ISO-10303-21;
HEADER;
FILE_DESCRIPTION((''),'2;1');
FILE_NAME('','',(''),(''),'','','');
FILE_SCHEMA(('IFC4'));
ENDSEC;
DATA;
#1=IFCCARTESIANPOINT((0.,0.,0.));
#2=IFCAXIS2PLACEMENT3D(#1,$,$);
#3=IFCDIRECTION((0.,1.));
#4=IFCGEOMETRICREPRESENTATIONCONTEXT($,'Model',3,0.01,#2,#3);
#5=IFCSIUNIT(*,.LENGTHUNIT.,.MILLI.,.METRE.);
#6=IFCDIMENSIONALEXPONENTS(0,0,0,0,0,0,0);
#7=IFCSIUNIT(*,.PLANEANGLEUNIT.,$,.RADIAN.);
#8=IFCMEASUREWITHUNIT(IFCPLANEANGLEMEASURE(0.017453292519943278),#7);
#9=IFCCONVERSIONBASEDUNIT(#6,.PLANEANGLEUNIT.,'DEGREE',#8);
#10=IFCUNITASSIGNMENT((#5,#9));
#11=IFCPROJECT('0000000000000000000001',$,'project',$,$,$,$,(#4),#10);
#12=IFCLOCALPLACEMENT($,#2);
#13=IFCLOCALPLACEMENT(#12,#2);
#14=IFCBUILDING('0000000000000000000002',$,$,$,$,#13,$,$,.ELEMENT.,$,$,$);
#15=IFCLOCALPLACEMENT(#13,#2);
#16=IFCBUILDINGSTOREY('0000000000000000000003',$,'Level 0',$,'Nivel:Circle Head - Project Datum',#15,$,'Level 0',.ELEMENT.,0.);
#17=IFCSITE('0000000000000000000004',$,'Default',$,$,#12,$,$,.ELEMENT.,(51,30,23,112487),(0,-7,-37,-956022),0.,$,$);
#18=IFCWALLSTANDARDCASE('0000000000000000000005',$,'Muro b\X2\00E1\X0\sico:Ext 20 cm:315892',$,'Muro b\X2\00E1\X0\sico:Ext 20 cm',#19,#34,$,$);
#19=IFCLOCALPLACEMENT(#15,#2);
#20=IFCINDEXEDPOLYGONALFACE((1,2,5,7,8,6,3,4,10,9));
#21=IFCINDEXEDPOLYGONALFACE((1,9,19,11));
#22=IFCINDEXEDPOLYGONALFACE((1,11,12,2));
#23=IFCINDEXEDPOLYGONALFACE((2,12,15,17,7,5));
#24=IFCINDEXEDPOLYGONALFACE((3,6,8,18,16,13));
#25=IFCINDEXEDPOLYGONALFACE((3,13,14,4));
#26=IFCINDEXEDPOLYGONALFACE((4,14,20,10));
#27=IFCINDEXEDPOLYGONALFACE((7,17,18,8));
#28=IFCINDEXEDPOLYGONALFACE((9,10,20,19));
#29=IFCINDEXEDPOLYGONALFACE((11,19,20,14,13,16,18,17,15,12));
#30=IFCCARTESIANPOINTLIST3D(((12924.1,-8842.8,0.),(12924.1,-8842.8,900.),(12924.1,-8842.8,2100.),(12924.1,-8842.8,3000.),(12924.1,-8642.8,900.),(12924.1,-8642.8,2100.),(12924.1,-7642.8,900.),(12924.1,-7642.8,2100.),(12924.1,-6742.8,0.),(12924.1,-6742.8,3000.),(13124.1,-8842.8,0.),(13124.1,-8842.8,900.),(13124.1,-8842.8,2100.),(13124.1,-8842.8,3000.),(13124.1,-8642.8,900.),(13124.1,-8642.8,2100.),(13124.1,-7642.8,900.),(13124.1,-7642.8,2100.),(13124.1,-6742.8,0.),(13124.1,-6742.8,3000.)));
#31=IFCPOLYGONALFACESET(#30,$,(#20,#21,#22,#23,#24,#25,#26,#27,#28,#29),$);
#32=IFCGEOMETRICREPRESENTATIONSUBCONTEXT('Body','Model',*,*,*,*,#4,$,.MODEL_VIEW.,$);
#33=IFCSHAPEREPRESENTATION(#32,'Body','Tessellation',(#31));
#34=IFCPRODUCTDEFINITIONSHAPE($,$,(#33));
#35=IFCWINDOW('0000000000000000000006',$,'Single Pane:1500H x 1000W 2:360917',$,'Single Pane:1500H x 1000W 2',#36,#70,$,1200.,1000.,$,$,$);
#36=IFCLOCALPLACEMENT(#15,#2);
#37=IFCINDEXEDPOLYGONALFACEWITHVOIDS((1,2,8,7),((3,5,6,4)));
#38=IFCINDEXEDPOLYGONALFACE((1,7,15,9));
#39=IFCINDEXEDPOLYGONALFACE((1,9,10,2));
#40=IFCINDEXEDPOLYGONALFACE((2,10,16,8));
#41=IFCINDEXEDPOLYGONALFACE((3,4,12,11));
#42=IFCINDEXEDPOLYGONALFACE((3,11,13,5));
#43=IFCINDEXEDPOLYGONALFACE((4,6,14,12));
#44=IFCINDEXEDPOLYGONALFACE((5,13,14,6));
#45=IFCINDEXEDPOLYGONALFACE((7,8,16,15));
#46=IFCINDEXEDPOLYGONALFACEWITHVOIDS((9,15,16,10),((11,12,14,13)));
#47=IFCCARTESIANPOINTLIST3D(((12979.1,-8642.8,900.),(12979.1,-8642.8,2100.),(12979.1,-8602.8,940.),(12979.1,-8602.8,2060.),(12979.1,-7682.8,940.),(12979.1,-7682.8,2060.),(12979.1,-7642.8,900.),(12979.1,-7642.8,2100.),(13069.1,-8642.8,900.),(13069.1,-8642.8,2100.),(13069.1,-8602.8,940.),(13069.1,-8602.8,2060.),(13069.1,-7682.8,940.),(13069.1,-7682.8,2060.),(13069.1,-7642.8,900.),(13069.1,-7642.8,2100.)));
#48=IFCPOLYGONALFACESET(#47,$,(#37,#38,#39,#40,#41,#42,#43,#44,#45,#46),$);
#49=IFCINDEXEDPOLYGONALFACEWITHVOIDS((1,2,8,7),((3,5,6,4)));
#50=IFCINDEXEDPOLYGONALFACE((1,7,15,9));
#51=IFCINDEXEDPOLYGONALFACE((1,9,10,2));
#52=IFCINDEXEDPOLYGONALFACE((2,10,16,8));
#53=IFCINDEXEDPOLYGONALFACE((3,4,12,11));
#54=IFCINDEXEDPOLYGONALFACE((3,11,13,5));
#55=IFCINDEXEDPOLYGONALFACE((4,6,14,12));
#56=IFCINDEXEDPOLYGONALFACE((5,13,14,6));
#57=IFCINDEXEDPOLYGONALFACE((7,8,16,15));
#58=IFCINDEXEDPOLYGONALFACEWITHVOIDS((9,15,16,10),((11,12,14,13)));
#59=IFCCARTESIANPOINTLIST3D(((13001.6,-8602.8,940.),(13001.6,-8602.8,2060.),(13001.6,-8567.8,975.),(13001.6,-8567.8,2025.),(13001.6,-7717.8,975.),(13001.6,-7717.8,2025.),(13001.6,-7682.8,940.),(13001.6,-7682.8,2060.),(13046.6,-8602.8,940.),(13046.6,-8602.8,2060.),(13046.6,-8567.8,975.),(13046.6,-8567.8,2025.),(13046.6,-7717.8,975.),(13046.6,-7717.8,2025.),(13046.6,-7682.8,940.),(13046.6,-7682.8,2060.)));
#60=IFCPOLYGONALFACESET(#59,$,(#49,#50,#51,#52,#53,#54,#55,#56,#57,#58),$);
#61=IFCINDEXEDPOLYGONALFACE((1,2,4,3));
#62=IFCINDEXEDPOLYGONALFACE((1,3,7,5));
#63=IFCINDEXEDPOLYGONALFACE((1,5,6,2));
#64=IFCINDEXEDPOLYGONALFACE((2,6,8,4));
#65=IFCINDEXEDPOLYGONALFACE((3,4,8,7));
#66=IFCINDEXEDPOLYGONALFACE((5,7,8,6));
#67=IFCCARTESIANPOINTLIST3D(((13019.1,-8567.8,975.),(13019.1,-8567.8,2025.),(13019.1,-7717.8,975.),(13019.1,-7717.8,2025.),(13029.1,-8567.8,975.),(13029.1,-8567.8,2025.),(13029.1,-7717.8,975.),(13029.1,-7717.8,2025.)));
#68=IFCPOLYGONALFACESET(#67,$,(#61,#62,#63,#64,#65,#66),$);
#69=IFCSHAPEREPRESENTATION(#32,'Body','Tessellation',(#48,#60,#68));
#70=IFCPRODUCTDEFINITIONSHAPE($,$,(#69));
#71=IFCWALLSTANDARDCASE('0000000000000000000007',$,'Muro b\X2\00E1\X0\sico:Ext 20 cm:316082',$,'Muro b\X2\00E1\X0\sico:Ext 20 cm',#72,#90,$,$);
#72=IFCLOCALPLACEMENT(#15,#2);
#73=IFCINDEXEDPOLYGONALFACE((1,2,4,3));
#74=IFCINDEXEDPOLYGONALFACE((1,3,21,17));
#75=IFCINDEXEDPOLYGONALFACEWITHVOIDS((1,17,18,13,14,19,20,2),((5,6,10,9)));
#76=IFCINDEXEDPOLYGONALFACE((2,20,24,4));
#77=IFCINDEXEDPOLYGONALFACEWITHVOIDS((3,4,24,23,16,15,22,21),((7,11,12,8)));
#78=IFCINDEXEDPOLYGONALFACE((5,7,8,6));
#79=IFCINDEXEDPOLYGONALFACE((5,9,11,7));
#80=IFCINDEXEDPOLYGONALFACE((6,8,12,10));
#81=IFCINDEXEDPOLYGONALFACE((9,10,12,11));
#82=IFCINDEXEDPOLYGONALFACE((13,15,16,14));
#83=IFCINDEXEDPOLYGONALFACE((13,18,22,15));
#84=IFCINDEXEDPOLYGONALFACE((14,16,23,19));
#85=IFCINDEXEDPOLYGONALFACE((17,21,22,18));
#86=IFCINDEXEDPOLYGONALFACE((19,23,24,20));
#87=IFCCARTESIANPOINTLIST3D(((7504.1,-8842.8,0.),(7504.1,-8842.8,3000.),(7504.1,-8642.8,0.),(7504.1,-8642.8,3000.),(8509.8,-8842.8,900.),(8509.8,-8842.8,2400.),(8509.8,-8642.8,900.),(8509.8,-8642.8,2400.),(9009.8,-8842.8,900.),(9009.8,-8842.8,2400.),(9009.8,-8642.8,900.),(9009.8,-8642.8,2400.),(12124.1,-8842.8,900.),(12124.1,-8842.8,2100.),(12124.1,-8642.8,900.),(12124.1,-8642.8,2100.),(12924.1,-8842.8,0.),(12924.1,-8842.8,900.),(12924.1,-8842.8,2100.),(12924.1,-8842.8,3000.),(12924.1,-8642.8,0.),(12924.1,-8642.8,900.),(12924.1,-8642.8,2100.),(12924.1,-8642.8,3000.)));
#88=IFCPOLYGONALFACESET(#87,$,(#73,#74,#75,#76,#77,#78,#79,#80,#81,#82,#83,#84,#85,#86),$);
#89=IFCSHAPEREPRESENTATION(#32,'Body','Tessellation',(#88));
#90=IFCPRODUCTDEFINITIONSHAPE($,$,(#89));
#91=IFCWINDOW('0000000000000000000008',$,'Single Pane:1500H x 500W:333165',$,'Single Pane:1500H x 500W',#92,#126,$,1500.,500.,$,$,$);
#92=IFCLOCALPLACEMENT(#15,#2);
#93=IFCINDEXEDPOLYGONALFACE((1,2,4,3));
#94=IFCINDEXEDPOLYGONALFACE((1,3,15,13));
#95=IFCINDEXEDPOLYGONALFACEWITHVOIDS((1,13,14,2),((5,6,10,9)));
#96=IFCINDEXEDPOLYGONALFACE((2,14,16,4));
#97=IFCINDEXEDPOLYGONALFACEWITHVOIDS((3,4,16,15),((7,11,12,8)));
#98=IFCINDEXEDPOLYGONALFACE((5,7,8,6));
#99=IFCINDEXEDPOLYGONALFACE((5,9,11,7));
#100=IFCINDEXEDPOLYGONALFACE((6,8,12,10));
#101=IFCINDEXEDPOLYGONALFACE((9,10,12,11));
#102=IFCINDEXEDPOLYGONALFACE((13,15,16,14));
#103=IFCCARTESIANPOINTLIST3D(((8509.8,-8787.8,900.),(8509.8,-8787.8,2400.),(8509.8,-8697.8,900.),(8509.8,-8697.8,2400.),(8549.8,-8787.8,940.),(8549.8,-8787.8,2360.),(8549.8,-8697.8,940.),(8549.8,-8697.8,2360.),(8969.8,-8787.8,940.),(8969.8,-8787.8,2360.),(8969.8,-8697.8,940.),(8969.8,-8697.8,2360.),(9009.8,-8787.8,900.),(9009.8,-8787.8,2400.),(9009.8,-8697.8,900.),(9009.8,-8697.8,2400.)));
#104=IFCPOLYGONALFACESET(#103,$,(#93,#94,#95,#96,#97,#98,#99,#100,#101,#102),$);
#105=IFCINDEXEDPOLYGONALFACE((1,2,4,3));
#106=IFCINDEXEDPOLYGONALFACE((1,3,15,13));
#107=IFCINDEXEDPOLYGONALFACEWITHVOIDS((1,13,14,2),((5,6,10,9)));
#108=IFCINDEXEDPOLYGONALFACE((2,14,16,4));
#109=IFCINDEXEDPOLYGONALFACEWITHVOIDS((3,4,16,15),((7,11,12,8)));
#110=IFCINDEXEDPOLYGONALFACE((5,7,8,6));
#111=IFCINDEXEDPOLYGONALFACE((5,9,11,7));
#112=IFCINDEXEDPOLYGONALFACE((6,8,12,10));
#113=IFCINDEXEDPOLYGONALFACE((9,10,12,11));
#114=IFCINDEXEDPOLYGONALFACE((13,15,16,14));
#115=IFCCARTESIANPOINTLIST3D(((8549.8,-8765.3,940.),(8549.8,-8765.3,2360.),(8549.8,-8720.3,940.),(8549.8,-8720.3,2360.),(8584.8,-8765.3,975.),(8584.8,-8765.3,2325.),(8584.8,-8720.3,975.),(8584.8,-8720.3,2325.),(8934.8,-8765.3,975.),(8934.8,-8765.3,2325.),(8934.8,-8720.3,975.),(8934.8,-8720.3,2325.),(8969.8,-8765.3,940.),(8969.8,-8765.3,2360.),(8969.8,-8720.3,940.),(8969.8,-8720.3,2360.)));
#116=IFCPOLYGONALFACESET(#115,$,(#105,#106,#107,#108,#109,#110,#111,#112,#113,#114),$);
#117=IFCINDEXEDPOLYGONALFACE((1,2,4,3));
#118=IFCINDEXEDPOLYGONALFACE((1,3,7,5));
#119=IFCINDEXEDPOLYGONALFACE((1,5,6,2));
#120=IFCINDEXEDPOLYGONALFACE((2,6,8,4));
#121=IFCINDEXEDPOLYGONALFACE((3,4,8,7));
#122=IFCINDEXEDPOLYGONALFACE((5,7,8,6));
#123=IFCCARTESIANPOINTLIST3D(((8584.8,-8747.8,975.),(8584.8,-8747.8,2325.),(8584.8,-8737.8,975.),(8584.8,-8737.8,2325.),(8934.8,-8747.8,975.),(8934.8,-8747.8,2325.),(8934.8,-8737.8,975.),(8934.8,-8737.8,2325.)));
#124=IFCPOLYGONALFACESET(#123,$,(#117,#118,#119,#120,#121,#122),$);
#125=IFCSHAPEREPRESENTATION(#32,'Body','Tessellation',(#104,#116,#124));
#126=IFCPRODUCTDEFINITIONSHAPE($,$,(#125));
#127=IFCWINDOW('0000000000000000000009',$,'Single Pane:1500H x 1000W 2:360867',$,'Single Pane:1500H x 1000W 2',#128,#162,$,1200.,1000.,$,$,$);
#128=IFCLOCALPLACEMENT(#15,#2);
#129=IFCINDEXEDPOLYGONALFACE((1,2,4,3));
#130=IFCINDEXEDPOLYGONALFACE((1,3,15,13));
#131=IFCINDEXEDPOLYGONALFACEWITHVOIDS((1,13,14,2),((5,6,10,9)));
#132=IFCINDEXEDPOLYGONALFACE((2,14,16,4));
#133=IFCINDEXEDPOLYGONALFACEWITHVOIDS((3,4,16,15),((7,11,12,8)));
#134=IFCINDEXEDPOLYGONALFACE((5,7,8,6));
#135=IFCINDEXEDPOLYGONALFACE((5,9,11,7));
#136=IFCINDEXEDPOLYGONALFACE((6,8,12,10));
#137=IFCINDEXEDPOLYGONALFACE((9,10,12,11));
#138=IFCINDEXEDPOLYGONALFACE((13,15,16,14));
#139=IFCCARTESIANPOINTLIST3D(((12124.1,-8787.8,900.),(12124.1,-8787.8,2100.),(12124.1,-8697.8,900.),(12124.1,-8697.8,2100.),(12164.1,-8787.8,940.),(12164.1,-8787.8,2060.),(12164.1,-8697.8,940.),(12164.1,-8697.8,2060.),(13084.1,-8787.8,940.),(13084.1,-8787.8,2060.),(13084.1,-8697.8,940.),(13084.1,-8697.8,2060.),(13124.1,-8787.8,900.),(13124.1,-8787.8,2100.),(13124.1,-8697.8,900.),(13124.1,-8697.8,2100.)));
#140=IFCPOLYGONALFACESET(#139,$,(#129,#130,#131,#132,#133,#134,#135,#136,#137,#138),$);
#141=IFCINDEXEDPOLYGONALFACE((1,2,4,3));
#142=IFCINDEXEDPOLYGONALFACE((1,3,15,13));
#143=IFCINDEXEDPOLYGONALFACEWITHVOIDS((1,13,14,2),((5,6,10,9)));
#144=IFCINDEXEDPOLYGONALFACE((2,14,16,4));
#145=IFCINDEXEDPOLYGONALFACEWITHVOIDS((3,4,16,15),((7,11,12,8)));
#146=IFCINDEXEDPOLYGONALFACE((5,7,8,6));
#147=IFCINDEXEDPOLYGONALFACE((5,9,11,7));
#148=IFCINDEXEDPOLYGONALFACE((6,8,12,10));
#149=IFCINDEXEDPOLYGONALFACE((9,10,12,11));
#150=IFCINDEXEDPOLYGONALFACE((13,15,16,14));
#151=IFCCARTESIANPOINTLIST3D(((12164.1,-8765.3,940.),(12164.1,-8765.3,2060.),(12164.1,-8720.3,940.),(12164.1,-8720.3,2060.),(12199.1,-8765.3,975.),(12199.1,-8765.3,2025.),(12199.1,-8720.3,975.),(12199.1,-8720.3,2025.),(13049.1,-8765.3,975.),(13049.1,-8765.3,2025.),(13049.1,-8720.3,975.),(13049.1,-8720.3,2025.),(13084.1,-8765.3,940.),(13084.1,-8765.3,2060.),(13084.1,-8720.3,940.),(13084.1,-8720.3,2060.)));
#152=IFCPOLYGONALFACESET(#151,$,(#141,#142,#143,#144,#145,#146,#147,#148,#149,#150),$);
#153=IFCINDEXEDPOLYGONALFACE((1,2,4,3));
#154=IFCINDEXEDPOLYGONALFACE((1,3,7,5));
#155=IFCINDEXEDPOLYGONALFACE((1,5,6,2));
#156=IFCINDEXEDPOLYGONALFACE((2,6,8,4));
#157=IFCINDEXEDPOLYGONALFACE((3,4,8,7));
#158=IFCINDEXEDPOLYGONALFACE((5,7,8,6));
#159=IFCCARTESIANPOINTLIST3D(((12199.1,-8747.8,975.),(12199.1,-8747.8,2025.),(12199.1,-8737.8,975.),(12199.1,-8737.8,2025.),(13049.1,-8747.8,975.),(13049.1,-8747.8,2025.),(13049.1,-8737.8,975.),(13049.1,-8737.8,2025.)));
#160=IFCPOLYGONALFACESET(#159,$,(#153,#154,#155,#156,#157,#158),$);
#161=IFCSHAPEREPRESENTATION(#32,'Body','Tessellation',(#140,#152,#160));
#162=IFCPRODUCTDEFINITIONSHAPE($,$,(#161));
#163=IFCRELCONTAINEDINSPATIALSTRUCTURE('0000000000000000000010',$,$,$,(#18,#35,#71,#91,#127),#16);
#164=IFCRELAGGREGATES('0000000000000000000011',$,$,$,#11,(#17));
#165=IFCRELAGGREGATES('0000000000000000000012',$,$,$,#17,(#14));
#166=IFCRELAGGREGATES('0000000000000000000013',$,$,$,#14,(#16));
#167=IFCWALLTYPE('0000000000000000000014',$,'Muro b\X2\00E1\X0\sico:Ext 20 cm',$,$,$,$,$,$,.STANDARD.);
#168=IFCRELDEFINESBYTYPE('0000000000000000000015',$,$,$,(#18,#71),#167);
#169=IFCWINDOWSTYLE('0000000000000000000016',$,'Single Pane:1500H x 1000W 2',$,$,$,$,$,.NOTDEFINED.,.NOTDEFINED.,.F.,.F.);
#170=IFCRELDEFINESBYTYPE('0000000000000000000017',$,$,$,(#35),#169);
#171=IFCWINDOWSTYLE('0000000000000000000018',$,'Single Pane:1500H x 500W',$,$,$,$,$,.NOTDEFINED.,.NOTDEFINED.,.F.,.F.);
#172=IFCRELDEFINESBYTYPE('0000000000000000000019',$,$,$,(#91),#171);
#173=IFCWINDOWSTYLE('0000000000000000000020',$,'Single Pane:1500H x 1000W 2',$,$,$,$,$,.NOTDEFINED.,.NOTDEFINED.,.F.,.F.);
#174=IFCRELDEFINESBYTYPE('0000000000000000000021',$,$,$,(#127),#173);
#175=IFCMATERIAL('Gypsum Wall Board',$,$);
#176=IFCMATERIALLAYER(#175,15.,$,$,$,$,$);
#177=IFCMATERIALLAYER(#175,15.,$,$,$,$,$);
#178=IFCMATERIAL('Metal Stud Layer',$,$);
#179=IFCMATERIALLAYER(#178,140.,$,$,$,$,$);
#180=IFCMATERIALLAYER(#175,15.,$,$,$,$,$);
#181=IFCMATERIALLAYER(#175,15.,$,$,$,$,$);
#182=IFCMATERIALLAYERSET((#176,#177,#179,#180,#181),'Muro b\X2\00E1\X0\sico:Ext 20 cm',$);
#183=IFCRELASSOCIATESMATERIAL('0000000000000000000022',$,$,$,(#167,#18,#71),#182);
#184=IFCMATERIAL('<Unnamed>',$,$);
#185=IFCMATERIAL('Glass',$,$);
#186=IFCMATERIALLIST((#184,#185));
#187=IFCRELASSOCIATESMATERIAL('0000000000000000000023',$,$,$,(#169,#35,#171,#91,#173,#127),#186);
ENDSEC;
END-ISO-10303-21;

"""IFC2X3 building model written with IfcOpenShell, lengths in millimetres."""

from ifc_helpers import new_model, entity, si_unit, converted_unit, direction, frame, frame_2d, origin, origin_2d_with_axis, place, context, subcontext, project, spatial, polyline, rectangle, outline, extrude, source, transform, mapped, material, material_list, layer, layer_set, layer_usage, type_object, type_shapes, element, fill, save


model = new_model("IFC2X3")

# Units and contexts
model_context = context("Model", 3, precision=0.01, world=origin(), true_north=direction((0.0, 1.0)))
body_context = subcontext(model_context, "Body", "Model", "MODEL_VIEW")
ifc_project = project(units=[si_unit("LENGTHUNIT", "METRE", prefix="MILLI"), converted_unit("PLANEANGLEUNIT", "DEGREE", entity("IfcPlaneAngleMeasure", 0.017453292519943278), si_unit("PLANEANGLEUNIT", "RADIAN"), dimensions=[0, 0, 0, 0, 0, 0, 0])], contexts=[model_context])

# Site, building, storey
site_placement = place(None, origin())
site = spatial("IfcSite", under=ifc_project, at=site_placement, Name="Default", CompositionType="ELEMENT", RefLatitude=(51, 30, 23, 112487), RefLongitude=(0, -7, -37, -956022), RefElevation=0.0)
building_placement = place(site_placement, origin())
building = spatial("IfcBuilding", under=site, at=building_placement, CompositionType="ELEMENT")
storey_placement = place(building_placement, origin())
storey = spatial("IfcBuildingStorey", under=building, at=storey_placement, Name="Level 0", ObjectType="Nivel:Circle Head - Project Datum", LongName="Level 0", CompositionType="ELEMENT", Elevation=0.0)

# Shared definitions
ifc_material_1 = material(Name="Gypsum Wall Board")
ifc_layer_1 = layer(ifc_material_1, 15.0)
ifc_layer_2 = layer(ifc_material_1, 15.0)
ifc_material_2 = material(Name="Metal Stud Layer")
ifc_layer_3 = layer(ifc_material_2, 140.0)
ifc_layer_4 = layer(ifc_material_1, 15.0)
ifc_layer_5 = layer(ifc_material_1, 15.0)
ifc_layer_set_1 = layer_set([ifc_layer_1, ifc_layer_2, ifc_layer_3, ifc_layer_4, ifc_layer_5], Name="Muro básico:Ext 20 cm")
wall_type_1 = type_object("IfcWallType", Name="Muro básico:Ext 20 cm", PredefinedType="STANDARD", material=ifc_layer_set_1)
ifc_material_3 = material(Name="Glass")
ifc_material_4 = material(Name="<Unnamed>")

# Wall, openings, window
ifc_layer_usage_1 = layer_usage(ifc_layer_set_1, "AXIS2", "NEGATIVE", 100.0)
wall_1_placement = place(storey_placement, frame((13024.1, -6742.8, 0.0), z_axis=(0.0, 0.0, 1.0), x_axis=(0.0, -1.0, 0.0)))
wall_1 = element("IfcWallStandardCase", 1, at=wall_1_placement, inside=storey, type_object=wall_type_1, material=ifc_layer_usage_1, Name="Muro básico:Ext 20 cm:315892", ObjectType="Muro básico:Ext 20 cm", context=body_context, shape_type="SweptSolid", body=[
    extrude(rectangle(XDim=2100.0, YDim=200.0, at=frame_2d((1050.0, 0.0), x_axis=(-1.0, 0.0))), origin(), (0.0, 0.0, 1.0), 3000.0),
])
opening_1_placement = place(wall_1_placement, origin())
element("IfcOpeningElement", 2, at=opening_1_placement, cuts=wall_1, ObjectType="Opening", context=body_context, shape_type="SweptSolid", body=[
    extrude(rectangle(XDim=1200.0, YDim=200.0, at=frame_2d((0.0, 0.0), x_axis=(0.0, 1.0))), frame((2000.0, -900.0, 1500.0), z_axis=(0.0, 1.0, 0.0), x_axis=(-1.0, 0.0, 0.0)), (0.0, 0.0, 1.0), 1000.0),
])
opening_2_placement = place(wall_1_placement, frame((1900.0, 100.0, 900.0)))
opening_2 = element("IfcOpeningElement", 3, at=opening_2_placement, cuts=wall_1, ObjectType="Opening", context=body_context, shape_type="SweptSolid", body=[
    extrude(rectangle(XDim=1200.0, YDim=1000.0, at=frame_2d((600.0, 500.0), x_axis=(1.0, 0.0))), frame((0.0, 0.0, 0.0), z_axis=(0.0, -1.0, 0.0), x_axis=(0.0, 0.0, 1.0)), (0.0, 0.0, 1.0), 200.0),
])
ifc_material_list_1 = material_list([ifc_material_4, ifc_material_3])
window_style_1 = type_object("IfcWindowStyle", Name="Single Pane:1500H x 1000W 2", ConstructionType="NOTDEFINED", OperationType="NOTDEFINED", ParameterTakesPrecedence=False, Sizeable=False, material=ifc_material_list_1)
shared_shape_1 = source(origin(), body_context, "Body", "SweptSolid", [
    extrude(outline(polyline([(-500.0, -600.0), (500.0, -600.0), (500.0, 600.0), (-500.0, 600.0), (-500.0, -600.0)]), holes=[polyline([(-460.0, -560.0), (-460.0, 560.0), (460.0, 560.0), (460.0, -560.0), (-460.0, -560.0)])]), frame((500.0, 55.0, 600.0), z_axis=(0.0, 1.0, 0.0), x_axis=(1.0, 0.0, 0.0)), (0.0, 0.0, 1.0), 90.0),
    extrude(outline(polyline([(-460.0, -560.0), (460.0, -560.0), (460.0, 560.0), (-460.0, 560.0), (-460.0, -560.0)]), holes=[polyline([(-425.0, -525.0), (-425.0, 525.0), (425.0, 525.0), (425.0, -525.0), (-425.0, -525.0)])]), frame((500.0, 77.5, 600.0), z_axis=(0.0, 1.0, 0.0), x_axis=(1.0, 0.0, 0.0)), (0.0, 0.0, 1.0), 45.0),
    extrude(rectangle(XDim=10.0, YDim=850.0, at=origin_2d_with_axis()), frame((500.0, 100.0, 75.0), z_axis=(0.0, 0.0, 1.0), x_axis=(0.0, 1.0, 0.0)), (0.0, 0.0, 1.0), 1050.0),
])
type_shapes(window_style_1, [shared_shape_1])
window_1_placement = place(opening_2_placement, frame((0.0, 0.0, 0.0), z_axis=(0.0, 0.0, 1.0), x_axis=(-1.0, 0.0, 0.0)))
window_1 = element("IfcWindow", 4, at=window_1_placement, inside=storey, type_object=window_style_1, material=ifc_material_list_1, Name="Single Pane:1500H x 1000W 2:360917", ObjectType="Single Pane:1500H x 1000W 2", OverallHeight=1200.0, OverallWidth=1000.0, context=body_context, shape_type="MappedRepresentation", body=[
    mapped(shared_shape_1, transform((0.0, 0.0, 0.0), scale=1.0)),
])
fill(opening_2, window_1)

# Wall, openings, windows
ifc_layer_usage_2 = layer_usage(ifc_layer_set_1, "AXIS2", "NEGATIVE", 100.0)
wall_2_placement = place(storey_placement, frame((12924.1, -8742.8, 0.0), z_axis=(0.0, 0.0, 1.0), x_axis=(-1.0, 0.0, 0.0)))
wall_2 = element("IfcWallStandardCase", 5, at=wall_2_placement, inside=storey, type_object=wall_type_1, material=ifc_layer_usage_2, Name="Muro básico:Ext 20 cm:316082", ObjectType="Muro básico:Ext 20 cm", context=body_context, shape_type="SweptSolid", body=[
    extrude(rectangle(XDim=5420.0, YDim=200.0, at=frame_2d((2710.0, 0.0), x_axis=(-1.0, 0.0))), origin(), (0.0, 0.0, 1.0), 3000.0),
])
opening_3_placement = place(wall_2_placement, frame((-200.0, -100.0, 900.0)))
opening_3 = element("IfcOpeningElement", 6, at=opening_3_placement, cuts=wall_2, ObjectType="Opening", context=body_context, shape_type="SweptSolid", body=[
    extrude(rectangle(XDim=1200.0, YDim=1000.0, at=frame_2d((600.0, 500.0), x_axis=(1.0, 0.0))), frame((0.0, 0.0, 0.0), z_axis=(0.0, 1.0, 0.0), x_axis=(0.0, 0.0, 1.0)), (0.0, 0.0, 1.0), 200.0),
])
opening_4_placement = place(wall_2_placement, frame((4414.3, 100.0, 900.0)))
opening_4 = element("IfcOpeningElement", 7, at=opening_4_placement, cuts=wall_2, ObjectType="Opening", context=body_context, shape_type="SweptSolid", body=[
    extrude(rectangle(XDim=1500.0, YDim=500.0, at=frame_2d((750.0, 250.0), x_axis=(1.0, 0.0))), frame((0.0, 0.0, 0.0), z_axis=(0.0, -1.0, 0.0), x_axis=(0.0, 0.0, 1.0)), (0.0, 0.0, 1.0), 200.0),
])
window_style_2 = type_object("IfcWindowStyle", Name="Single Pane:1500H x 500W", ConstructionType="NOTDEFINED", OperationType="NOTDEFINED", ParameterTakesPrecedence=False, Sizeable=False, material=ifc_material_list_1)
shared_shape_2 = source(origin(), body_context, "Body", "SweptSolid", [
    extrude(outline(polyline([(-250.0, -750.0), (250.0, -750.0), (250.0, 750.0), (-250.0, 750.0), (-250.0, -750.0)]), holes=[polyline([(-210.0, -710.0), (-210.0, 710.0), (210.0, 710.0), (210.0, -710.0), (-210.0, -710.0)])]), frame((250.0, 55.0, 750.0), z_axis=(0.0, 1.0, 0.0), x_axis=(1.0, 0.0, 0.0)), (0.0, 0.0, 1.0), 90.0),
    extrude(outline(polyline([(-210.0, -710.0), (210.0, -710.0), (210.0, 710.0), (-210.0, 710.0), (-210.0, -710.0)]), holes=[polyline([(-175.0, -675.0), (-175.0, 675.0), (175.0, 675.0), (175.0, -675.0), (-175.0, -675.0)])]), frame((250.0, 77.5, 750.0), z_axis=(0.0, 1.0, 0.0), x_axis=(1.0, 0.0, 0.0)), (0.0, 0.0, 1.0), 45.0),
    extrude(rectangle(XDim=10.0, YDim=350.0, at=origin_2d_with_axis()), frame((250.0, 100.0, 75.0), z_axis=(0.0, 0.0, 1.0), x_axis=(0.0, 1.0, 0.0)), (0.0, 0.0, 1.0), 1350.0),
])
type_shapes(window_style_2, [shared_shape_2])
window_2_placement = place(opening_4_placement, frame((0.0, 0.0, 0.0), z_axis=(0.0, 0.0, 1.0), x_axis=(-1.0, 0.0, 0.0)))
window_2 = element("IfcWindow", 8, at=window_2_placement, inside=storey, type_object=window_style_2, material=ifc_material_list_1, Name="Single Pane:1500H x 500W:333165", ObjectType="Single Pane:1500H x 500W", OverallHeight=1500.0, OverallWidth=500.0, context=body_context, shape_type="MappedRepresentation", body=[
    mapped(shared_shape_2, transform((0.0, 0.0, 0.0), scale=1.0)),
])
fill(opening_4, window_2)
window_style_3 = type_object("IfcWindowStyle", Name="Single Pane:1500H x 1000W 2", ConstructionType="NOTDEFINED", OperationType="NOTDEFINED", ParameterTakesPrecedence=False, Sizeable=False, material=ifc_material_list_1)
shared_shape_3 = source(origin(), body_context, "Body", "SweptSolid", [
    extrude(outline(polyline([(-500.0, -600.0), (500.0, -600.0), (500.0, 600.0), (-500.0, 600.0), (-500.0, -600.0)]), holes=[polyline([(-460.0, -560.0), (-460.0, 560.0), (460.0, 560.0), (460.0, -560.0), (-460.0, -560.0)])]), frame((500.0, 55.0, 600.0), z_axis=(0.0, 1.0, 0.0), x_axis=(1.0, 0.0, 0.0)), (0.0, 0.0, 1.0), 90.0),
    extrude(outline(polyline([(-460.0, -560.0), (460.0, -560.0), (460.0, 560.0), (-460.0, 560.0), (-460.0, -560.0)]), holes=[polyline([(-425.0, -525.0), (-425.0, 525.0), (425.0, 525.0), (425.0, -525.0), (-425.0, -525.0)])]), frame((500.0, 77.5, 600.0), z_axis=(0.0, 1.0, 0.0), x_axis=(1.0, 0.0, 0.0)), (0.0, 0.0, 1.0), 45.0),
    extrude(rectangle(XDim=10.0, YDim=850.0, at=origin_2d_with_axis()), frame((500.0, 100.0, 75.0), z_axis=(0.0, 0.0, 1.0), x_axis=(0.0, 1.0, 0.0)), (0.0, 0.0, 1.0), 1050.0),
])
type_shapes(window_style_3, [shared_shape_3])
window_3_placement = place(opening_3_placement, origin())
window_3 = element("IfcWindow", 9, at=window_3_placement, inside=storey, type_object=window_style_3, material=ifc_material_list_1, Name="Single Pane:1500H x 1000W 2:360867", ObjectType="Single Pane:1500H x 1000W 2", OverallHeight=1200.0, OverallWidth=1000.0, context=body_context, shape_type="MappedRepresentation", body=[
    mapped(shared_shape_3, transform((0.0, 0.0, 0.0), scale=1.0)),
])
fill(opening_3, window_3)

save(model, "model.ifc")
